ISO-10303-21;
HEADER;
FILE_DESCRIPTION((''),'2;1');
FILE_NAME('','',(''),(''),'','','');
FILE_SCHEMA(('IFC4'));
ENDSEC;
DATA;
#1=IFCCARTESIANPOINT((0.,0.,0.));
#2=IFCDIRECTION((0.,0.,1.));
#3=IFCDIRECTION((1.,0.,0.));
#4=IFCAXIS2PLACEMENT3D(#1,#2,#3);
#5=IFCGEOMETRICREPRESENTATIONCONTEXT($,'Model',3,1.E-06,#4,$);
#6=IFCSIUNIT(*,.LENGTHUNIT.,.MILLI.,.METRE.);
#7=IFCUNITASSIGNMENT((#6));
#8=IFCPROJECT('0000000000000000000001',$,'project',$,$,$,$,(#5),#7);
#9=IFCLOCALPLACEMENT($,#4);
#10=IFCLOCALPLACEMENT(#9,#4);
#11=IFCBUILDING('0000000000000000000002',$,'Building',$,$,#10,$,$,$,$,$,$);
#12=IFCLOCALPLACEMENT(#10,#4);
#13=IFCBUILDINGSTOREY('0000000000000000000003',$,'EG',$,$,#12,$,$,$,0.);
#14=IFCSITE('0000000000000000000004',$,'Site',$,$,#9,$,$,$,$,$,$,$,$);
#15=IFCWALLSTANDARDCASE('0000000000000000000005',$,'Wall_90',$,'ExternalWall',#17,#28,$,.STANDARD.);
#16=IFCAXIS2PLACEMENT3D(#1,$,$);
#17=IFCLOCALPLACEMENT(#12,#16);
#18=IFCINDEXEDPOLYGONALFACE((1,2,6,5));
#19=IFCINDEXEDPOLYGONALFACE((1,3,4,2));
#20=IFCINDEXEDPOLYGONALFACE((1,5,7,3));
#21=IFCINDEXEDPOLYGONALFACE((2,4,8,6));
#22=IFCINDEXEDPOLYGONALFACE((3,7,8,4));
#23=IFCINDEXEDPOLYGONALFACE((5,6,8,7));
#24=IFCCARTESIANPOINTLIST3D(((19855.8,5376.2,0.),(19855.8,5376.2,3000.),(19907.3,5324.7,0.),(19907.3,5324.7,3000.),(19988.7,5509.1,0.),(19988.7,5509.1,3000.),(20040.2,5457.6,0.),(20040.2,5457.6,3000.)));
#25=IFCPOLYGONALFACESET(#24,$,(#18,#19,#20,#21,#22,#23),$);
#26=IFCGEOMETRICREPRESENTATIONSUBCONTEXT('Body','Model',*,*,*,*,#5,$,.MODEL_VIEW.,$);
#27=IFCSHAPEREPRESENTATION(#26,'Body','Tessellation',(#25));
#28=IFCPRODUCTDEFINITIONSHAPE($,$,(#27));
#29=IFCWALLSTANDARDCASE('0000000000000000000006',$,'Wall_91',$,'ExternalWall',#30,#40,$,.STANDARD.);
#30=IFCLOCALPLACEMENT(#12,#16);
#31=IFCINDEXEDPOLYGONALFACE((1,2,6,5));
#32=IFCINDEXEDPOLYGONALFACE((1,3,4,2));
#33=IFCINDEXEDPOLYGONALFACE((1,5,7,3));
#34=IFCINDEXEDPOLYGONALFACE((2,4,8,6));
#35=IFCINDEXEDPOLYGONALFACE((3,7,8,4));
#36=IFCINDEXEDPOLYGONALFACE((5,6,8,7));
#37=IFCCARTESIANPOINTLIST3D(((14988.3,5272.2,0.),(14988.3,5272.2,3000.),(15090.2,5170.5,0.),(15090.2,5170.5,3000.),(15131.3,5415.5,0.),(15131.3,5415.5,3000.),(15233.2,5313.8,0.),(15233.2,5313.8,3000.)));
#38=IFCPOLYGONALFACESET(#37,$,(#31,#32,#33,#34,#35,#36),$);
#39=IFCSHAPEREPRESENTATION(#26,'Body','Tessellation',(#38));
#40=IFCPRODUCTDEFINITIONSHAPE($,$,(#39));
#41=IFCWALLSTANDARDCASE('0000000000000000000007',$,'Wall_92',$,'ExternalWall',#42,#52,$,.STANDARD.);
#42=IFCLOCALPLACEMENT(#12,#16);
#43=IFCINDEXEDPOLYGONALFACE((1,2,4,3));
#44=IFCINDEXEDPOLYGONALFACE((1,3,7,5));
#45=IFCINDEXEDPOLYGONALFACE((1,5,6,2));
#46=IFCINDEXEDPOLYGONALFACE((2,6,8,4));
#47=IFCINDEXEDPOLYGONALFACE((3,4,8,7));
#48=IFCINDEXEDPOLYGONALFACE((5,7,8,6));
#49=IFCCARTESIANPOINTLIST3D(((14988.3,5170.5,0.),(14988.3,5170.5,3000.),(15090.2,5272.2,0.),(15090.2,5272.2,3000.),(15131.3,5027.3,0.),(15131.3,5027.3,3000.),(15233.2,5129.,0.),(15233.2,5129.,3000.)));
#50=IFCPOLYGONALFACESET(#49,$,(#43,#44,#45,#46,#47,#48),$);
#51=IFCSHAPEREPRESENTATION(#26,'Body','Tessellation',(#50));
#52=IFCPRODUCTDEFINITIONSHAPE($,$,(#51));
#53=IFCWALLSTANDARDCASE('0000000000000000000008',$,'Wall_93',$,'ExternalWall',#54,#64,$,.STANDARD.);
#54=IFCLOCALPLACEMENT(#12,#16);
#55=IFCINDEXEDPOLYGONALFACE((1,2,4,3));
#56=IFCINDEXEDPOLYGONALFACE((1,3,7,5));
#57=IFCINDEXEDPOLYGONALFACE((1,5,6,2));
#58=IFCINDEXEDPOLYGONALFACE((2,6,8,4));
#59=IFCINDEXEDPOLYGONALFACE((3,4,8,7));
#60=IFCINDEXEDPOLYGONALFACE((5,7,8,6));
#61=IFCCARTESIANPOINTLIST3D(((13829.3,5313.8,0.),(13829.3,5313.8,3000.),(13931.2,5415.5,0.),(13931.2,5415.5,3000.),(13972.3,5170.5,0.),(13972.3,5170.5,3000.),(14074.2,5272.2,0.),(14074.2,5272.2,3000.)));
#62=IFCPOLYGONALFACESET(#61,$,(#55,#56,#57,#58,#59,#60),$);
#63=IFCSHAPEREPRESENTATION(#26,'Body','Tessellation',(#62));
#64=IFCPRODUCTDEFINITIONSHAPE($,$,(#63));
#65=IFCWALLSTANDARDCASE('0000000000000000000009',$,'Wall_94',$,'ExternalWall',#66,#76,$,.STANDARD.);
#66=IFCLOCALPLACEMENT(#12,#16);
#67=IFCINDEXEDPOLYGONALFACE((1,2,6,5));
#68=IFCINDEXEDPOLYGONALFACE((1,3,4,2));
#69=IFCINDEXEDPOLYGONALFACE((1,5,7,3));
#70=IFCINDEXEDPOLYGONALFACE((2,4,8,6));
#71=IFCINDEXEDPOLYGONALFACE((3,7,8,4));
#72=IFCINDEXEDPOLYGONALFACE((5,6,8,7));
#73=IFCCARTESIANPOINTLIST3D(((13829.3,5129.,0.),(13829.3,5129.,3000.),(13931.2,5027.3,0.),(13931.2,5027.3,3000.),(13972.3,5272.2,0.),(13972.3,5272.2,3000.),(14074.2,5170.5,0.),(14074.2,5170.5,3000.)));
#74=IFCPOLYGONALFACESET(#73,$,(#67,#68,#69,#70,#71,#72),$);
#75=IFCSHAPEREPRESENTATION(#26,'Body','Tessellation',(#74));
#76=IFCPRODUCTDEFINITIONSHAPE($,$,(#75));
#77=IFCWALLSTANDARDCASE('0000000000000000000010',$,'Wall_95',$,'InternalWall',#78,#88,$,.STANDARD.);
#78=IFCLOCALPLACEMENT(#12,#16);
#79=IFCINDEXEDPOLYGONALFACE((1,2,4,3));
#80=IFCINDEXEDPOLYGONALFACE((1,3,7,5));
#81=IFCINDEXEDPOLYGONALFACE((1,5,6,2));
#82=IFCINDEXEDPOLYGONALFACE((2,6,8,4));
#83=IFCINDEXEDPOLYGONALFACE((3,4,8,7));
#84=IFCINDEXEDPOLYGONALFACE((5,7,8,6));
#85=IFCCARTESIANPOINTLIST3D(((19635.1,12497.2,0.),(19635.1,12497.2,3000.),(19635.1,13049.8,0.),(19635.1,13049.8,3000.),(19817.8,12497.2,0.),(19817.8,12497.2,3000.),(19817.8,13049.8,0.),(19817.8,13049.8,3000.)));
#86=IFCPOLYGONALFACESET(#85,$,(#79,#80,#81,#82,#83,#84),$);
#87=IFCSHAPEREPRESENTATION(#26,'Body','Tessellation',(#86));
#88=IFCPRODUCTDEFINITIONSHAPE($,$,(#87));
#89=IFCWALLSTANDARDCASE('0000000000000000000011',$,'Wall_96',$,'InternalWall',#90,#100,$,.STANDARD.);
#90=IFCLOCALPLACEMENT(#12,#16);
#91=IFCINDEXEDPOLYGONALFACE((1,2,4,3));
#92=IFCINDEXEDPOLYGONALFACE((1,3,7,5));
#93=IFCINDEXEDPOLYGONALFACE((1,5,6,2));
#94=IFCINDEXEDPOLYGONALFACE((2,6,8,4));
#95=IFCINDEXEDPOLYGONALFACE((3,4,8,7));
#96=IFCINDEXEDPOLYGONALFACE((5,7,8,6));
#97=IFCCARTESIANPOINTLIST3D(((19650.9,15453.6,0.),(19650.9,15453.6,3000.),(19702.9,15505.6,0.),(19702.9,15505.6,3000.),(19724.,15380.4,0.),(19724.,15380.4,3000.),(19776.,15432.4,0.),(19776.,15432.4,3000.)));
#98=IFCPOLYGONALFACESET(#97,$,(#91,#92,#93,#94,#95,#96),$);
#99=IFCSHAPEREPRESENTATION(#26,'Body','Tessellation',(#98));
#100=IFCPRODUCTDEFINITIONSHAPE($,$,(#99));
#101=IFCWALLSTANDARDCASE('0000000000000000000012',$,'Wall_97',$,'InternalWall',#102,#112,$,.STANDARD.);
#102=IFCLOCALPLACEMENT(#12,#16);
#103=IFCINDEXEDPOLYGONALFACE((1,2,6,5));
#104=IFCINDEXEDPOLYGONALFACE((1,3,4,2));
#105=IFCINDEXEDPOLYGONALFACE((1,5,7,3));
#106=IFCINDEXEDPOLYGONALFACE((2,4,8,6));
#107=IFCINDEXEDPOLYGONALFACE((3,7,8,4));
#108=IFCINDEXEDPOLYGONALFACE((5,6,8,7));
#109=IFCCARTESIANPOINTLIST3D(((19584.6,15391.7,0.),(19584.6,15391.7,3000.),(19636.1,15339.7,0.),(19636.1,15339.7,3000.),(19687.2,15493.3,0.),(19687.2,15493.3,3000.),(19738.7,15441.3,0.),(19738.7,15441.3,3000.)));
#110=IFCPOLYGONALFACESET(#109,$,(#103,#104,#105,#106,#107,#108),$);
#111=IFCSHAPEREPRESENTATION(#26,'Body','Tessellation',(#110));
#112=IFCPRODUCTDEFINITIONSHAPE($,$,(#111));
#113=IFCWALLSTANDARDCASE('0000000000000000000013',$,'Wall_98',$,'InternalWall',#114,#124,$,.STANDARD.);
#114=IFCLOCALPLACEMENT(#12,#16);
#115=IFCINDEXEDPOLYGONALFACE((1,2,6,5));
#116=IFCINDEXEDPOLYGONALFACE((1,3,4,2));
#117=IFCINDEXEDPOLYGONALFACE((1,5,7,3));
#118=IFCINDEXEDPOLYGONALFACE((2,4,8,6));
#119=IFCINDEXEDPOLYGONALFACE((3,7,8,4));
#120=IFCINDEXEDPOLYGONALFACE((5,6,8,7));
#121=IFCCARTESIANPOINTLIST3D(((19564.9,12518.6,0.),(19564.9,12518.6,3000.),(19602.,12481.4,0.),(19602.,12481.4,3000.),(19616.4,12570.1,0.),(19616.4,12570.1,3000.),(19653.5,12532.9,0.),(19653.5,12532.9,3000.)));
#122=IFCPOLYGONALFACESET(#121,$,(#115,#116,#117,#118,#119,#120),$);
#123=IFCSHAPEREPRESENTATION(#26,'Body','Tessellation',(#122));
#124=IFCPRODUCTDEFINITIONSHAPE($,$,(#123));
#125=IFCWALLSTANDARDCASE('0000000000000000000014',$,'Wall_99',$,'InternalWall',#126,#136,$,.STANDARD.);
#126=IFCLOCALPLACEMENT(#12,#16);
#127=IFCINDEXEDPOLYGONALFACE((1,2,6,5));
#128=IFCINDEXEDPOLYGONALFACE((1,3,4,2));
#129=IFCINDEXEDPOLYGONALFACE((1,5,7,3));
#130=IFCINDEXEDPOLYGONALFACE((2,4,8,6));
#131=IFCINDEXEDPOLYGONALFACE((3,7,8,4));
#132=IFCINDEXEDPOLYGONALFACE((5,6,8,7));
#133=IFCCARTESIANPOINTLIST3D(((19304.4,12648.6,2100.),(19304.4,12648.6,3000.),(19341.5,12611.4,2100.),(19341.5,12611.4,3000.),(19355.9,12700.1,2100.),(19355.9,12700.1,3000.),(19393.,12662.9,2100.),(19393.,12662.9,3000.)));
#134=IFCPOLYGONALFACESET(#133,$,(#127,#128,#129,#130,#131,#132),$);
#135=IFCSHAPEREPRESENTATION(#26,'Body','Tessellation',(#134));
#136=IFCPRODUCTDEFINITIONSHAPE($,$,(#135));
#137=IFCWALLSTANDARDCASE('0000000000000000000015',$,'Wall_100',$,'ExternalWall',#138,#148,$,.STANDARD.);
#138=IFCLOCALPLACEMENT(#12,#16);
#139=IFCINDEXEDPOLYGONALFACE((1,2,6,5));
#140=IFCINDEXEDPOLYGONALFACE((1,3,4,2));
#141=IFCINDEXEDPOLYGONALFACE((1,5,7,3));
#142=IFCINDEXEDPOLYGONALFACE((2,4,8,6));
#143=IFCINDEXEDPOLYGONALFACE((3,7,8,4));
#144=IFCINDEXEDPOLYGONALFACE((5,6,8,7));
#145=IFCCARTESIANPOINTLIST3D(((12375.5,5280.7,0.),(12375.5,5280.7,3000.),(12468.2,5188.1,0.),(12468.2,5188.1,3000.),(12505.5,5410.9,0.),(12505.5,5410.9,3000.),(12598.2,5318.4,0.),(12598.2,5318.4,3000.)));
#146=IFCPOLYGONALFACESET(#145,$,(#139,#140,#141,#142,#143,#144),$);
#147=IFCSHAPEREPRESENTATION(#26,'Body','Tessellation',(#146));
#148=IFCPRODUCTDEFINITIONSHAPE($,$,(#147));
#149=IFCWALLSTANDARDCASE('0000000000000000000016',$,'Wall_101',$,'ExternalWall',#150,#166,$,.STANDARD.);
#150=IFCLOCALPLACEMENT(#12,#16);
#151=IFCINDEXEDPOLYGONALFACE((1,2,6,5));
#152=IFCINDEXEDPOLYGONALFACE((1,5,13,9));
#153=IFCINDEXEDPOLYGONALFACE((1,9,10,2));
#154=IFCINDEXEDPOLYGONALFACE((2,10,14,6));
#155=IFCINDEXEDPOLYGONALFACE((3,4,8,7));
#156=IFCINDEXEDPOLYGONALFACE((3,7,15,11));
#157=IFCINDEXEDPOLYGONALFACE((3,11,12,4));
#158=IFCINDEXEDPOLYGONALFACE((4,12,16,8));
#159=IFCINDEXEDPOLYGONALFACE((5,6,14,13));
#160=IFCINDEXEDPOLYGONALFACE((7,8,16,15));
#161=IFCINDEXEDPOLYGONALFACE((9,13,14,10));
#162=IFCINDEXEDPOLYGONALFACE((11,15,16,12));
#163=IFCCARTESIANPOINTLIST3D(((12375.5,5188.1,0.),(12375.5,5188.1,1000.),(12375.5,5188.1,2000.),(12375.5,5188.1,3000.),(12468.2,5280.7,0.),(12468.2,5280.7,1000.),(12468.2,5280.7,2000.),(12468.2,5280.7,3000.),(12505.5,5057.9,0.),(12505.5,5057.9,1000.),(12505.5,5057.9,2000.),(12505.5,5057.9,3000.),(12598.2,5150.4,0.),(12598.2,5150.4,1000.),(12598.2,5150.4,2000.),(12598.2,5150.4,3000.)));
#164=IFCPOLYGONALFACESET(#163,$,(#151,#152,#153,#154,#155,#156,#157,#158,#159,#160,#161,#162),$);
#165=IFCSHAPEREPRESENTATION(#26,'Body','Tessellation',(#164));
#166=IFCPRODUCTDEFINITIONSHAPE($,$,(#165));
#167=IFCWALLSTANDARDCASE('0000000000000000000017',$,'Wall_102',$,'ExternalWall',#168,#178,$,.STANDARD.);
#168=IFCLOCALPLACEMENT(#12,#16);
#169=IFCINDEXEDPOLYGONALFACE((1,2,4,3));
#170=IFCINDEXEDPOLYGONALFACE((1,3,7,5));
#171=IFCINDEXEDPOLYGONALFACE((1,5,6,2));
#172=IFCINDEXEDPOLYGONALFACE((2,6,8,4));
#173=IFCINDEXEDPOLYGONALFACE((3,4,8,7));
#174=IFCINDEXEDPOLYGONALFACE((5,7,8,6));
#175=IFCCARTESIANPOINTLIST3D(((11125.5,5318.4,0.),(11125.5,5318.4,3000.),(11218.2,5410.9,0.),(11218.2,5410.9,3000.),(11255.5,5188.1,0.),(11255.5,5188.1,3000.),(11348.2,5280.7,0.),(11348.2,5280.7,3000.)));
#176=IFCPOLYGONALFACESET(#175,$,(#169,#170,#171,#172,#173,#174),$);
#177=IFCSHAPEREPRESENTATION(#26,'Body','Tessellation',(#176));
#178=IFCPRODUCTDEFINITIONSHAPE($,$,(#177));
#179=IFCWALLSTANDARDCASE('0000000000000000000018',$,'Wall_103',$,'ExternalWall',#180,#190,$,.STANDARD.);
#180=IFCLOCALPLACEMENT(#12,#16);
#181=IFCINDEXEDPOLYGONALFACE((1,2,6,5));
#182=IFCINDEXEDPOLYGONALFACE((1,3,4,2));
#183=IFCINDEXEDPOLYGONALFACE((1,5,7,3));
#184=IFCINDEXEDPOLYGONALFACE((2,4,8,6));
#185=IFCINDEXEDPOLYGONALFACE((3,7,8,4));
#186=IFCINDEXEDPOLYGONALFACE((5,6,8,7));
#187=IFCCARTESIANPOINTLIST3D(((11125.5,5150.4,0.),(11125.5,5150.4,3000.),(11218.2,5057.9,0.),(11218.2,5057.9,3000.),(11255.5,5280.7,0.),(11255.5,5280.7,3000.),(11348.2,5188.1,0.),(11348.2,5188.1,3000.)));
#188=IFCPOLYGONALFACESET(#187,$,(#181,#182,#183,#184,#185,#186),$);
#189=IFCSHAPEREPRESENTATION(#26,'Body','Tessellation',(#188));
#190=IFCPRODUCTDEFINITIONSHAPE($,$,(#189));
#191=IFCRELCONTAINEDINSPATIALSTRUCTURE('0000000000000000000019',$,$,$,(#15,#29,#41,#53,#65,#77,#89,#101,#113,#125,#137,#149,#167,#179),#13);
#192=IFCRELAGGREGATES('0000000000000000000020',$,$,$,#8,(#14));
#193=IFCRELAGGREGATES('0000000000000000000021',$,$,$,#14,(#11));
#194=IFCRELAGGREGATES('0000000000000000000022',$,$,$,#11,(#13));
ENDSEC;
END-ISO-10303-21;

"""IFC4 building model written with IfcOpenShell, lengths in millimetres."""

from ifc_helpers import new_model, si_unit, frame, origin_with_axes, place, context, subcontext, project, spatial, rectangle, extrude, element, save


model = new_model("IFC4")

# Units and contexts
model_context = context("Model", 3, precision=1e-06, world=origin_with_axes())
body_context = subcontext(model_context, "Body", "Model", "MODEL_VIEW")
ifc_project = project(units=[si_unit("LENGTHUNIT", "METRE", prefix="MILLI")], contexts=[model_context])

# Site, building, storey
site_placement = place(None, origin_with_axes())
site = spatial("IfcSite", under=ifc_project, at=site_placement, Name="Site")
building_placement = place(site_placement, origin_with_axes())
building = spatial("IfcBuilding", under=site, at=building_placement, Name="Building")
storey_placement = place(building_placement, origin_with_axes())
storey = spatial("IfcBuildingStorey", under=building, at=storey_placement, Name="EG", Elevation=0.0)

# Walls
wall_1_placement = place(storey_placement, origin_with_axes())
element("IfcWallStandardCase", 1, at=wall_1_placement, inside=storey, Name="Wall_90", ObjectType="ExternalWall", PredefinedType="STANDARD", context=body_context, shape_type="SweptSolid", body=[
    extrude(rectangle(XDim=72.8, YDim=187.9), frame((19948.0, 5416.9, 0.0), z_axis=(0.0, 0.0, 1.0), x_axis=(0.707107, -0.707107, 0.0)), (0.0, 0.0, 1.0), 3000.0),
])
wall_2_placement = place(storey_placement, origin_with_axes())
element("IfcWallStandardCase", 2, at=wall_2_placement, inside=storey, Name="Wall_91", ObjectType="ExternalWall", PredefinedType="STANDARD", context=body_context, shape_type="SweptSolid", body=[
    extrude(rectangle(XDim=202.4, YDim=144.0), frame((15110.7, 5293.0, 0.0), z_axis=(0.0, 0.0, 1.0), x_axis=(0.706489, 0.707724, 0.0)), (0.0, 0.0, 1.0), 3000.0),
])
wall_3_placement = place(storey_placement, origin_with_axes())
element("IfcWallStandardCase", 3, at=wall_3_placement, inside=storey, Name="Wall_92", ObjectType="ExternalWall", PredefinedType="STANDARD", context=body_context, shape_type="SweptSolid", body=[
    extrude(rectangle(XDim=202.4, YDim=144.0), frame((15110.7, 5149.8, 0.0), z_axis=(0.0, 0.0, 1.0), x_axis=(0.706489, -0.707724, 0.0)), (0.0, 0.0, 1.0), 3000.0),
])
wall_4_placement = place(storey_placement, origin_with_axes())
element("IfcWallStandardCase", 4, at=wall_4_placement, inside=storey, Name="Wall_93", ObjectType="ExternalWall", PredefinedType="STANDARD", context=body_context, shape_type="SweptSolid", body=[
    extrude(rectangle(XDim=202.4, YDim=144.0), frame((13951.7, 5293.0, 0.0), z_axis=(0.0, 0.0, 1.0), x_axis=(-0.706489, 0.707724, 0.0)), (0.0, 0.0, 1.0), 3000.0),
])
wall_5_placement = place(storey_placement, origin_with_axes())
element("IfcWallStandardCase", 5, at=wall_5_placement, inside=storey, Name="Wall_94", ObjectType="ExternalWall", PredefinedType="STANDARD", context=body_context, shape_type="SweptSolid", body=[
    extrude(rectangle(XDim=202.4, YDim=144.0), frame((13951.7, 5149.8, 0.0), z_axis=(0.0, 0.0, 1.0), x_axis=(-0.706489, -0.707724, 0.0)), (0.0, 0.0, 1.0), 3000.0),
])
wall_6_placement = place(storey_placement, origin_with_axes())
element("IfcWallStandardCase", 6, at=wall_6_placement, inside=storey, Name="Wall_95", ObjectType="InternalWall", PredefinedType="STANDARD", context=body_context, shape_type="SweptSolid", body=[
    extrude(rectangle(XDim=552.5, YDim=182.7), frame((19726.4, 12773.5, 0.0), z_axis=(0.0, 0.0, 1.0), x_axis=(0.0, -1.0, 0.0)), (0.0, 0.0, 1.0), 3000.0),
])
wall_7_placement = place(storey_placement, origin_with_axes())
element("IfcWallStandardCase", 7, at=wall_7_placement, inside=storey, Name="Wall_96", ObjectType="InternalWall", PredefinedType="STANDARD", context=body_context, shape_type="SweptSolid", body=[
    extrude(rectangle(XDim=73.5, YDim=103.4), frame((19713.4, 15443.0, 0.0), z_axis=(0.0, 0.0, 1.0), x_axis=(-0.707107, -0.707107, 0.0)), (0.0, 0.0, 1.0), 3000.0),
])
wall_8_placement = place(storey_placement, origin_with_axes())
element("IfcWallStandardCase", 8, at=wall_8_placement, inside=storey, Name="Wall_97", ObjectType="InternalWall", PredefinedType="STANDARD", context=body_context, shape_type="SweptSolid", body=[
    extrude(rectangle(XDim=73.2, YDim=144.4), frame((19661.7, 15416.5, 0.0), z_axis=(0.0, 0.0, 1.0), x_axis=(-0.703683, 0.710514, 0.0)), (0.0, 0.0, 1.0), 3000.0),
])
wall_9_placement = place(storey_placement, origin_with_axes())
element("IfcWallStandardCase", 9, at=wall_9_placement, inside=storey, Name="Wall_98", ObjectType="InternalWall", PredefinedType="STANDARD", context=body_context, shape_type="SweptSolid", body=[
    extrude(rectangle(XDim=72.8, YDim=52.5), frame((19609.2, 12525.8, 0.0), z_axis=(0.0, 0.0, 1.0), x_axis=(-0.707107, -0.707107, 0.0)), (0.0, 0.0, 1.0), 3000.0),
])

# Wall, opening
wall_10_placement = place(storey_placement, origin_with_axes())
wall_10 = element("IfcWallStandardCase", 10, at=wall_10_placement, inside=storey, Name="Wall_99", ObjectType="InternalWall", PredefinedType="STANDARD", context=body_context, shape_type="SweptSolid", body=[
    extrude(rectangle(XDim=72.8, YDim=52.5), frame((19348.7, 12655.8, 0.0), z_axis=(0.0, 0.0, 1.0), x_axis=(-0.707107, -0.707107, 0.0)), (0.0, 0.0, 1.0), 3000.0),
])
opening_1_placement = place(wall_10_placement, origin_with_axes())
element("IfcOpeningElement", 11, at=opening_1_placement, inside=storey, cuts=wall_10, context=body_context, shape_type="SweptSolid", body=[
    extrude(rectangle(XDim=450.0, YDim=52.5), frame((19348.7, 12655.8, 0.0), z_axis=(0.0, 0.0, 1.0), x_axis=(-0.707107, -0.707107, 0.0)), (0.0, 0.0, 1.0), 2100.0),
])

# Wall
wall_11_placement = place(storey_placement, origin_with_axes())
element("IfcWallStandardCase", 12, at=wall_11_placement, inside=storey, Name="Wall_100", ObjectType="ExternalWall", PredefinedType="STANDARD", context=body_context, shape_type="SweptSolid", body=[
    extrude(rectangle(XDim=184.0, YDim=131.0), frame((12486.9, 5299.5, 0.0), z_axis=(0.0, 0.0, 1.0), x_axis=(0.706427, 0.707786, 0.0)), (0.0, 0.0, 1.0), 3000.0),
])

# Wall, opening
wall_12_placement = place(storey_placement, origin_with_axes())
wall_12 = element("IfcWallStandardCase", 13, at=wall_12_placement, inside=storey, Name="Wall_101", ObjectType="ExternalWall", PredefinedType="STANDARD", context=body_context, shape_type="SweptSolid", body=[
    extrude(rectangle(XDim=184.0, YDim=131.0), frame((12486.9, 5169.3, 0.0), z_axis=(0.0, 0.0, 1.0), x_axis=(0.706427, -0.707786, 0.0)), (0.0, 0.0, 1.0), 3000.0),
])
opening_2_placement = place(wall_12_placement, origin_with_axes())
element("IfcOpeningElement", 14, at=opening_2_placement, inside=storey, cuts=wall_12, context=body_context, shape_type="SweptSolid", body=[
    extrude(rectangle(XDim=600.0, YDim=131.0), frame((12486.9, 5169.3, 1000.0), z_axis=(0.0, 0.0, 1.0), x_axis=(0.706427, -0.707786, 0.0)), (0.0, 0.0, 1.0), 1000.0),
])

# Walls
wall_13_placement = place(storey_placement, origin_with_axes())
element("IfcWallStandardCase", 15, at=wall_13_placement, inside=storey, Name="Wall_102", ObjectType="ExternalWall", PredefinedType="STANDARD", context=body_context, shape_type="SweptSolid", body=[
    extrude(rectangle(XDim=184.0, YDim=131.0), frame((11236.9, 5299.5, 0.0), z_axis=(0.0, 0.0, 1.0), x_axis=(-0.706427, 0.707786, 0.0)), (0.0, 0.0, 1.0), 3000.0),
])
wall_14_placement = place(storey_placement, origin_with_axes())
element("IfcWallStandardCase", 16, at=wall_14_placement, inside=storey, Name="Wall_103", ObjectType="ExternalWall", PredefinedType="STANDARD", context=body_context, shape_type="SweptSolid", body=[
    extrude(rectangle(XDim=184.0, YDim=131.0), frame((11236.9, 5169.3, 0.0), z_axis=(0.0, 0.0, 1.0), x_axis=(-0.706427, -0.707786, 0.0)), (0.0, 0.0, 1.0), 3000.0),
])

save(model, "model.ifc")
